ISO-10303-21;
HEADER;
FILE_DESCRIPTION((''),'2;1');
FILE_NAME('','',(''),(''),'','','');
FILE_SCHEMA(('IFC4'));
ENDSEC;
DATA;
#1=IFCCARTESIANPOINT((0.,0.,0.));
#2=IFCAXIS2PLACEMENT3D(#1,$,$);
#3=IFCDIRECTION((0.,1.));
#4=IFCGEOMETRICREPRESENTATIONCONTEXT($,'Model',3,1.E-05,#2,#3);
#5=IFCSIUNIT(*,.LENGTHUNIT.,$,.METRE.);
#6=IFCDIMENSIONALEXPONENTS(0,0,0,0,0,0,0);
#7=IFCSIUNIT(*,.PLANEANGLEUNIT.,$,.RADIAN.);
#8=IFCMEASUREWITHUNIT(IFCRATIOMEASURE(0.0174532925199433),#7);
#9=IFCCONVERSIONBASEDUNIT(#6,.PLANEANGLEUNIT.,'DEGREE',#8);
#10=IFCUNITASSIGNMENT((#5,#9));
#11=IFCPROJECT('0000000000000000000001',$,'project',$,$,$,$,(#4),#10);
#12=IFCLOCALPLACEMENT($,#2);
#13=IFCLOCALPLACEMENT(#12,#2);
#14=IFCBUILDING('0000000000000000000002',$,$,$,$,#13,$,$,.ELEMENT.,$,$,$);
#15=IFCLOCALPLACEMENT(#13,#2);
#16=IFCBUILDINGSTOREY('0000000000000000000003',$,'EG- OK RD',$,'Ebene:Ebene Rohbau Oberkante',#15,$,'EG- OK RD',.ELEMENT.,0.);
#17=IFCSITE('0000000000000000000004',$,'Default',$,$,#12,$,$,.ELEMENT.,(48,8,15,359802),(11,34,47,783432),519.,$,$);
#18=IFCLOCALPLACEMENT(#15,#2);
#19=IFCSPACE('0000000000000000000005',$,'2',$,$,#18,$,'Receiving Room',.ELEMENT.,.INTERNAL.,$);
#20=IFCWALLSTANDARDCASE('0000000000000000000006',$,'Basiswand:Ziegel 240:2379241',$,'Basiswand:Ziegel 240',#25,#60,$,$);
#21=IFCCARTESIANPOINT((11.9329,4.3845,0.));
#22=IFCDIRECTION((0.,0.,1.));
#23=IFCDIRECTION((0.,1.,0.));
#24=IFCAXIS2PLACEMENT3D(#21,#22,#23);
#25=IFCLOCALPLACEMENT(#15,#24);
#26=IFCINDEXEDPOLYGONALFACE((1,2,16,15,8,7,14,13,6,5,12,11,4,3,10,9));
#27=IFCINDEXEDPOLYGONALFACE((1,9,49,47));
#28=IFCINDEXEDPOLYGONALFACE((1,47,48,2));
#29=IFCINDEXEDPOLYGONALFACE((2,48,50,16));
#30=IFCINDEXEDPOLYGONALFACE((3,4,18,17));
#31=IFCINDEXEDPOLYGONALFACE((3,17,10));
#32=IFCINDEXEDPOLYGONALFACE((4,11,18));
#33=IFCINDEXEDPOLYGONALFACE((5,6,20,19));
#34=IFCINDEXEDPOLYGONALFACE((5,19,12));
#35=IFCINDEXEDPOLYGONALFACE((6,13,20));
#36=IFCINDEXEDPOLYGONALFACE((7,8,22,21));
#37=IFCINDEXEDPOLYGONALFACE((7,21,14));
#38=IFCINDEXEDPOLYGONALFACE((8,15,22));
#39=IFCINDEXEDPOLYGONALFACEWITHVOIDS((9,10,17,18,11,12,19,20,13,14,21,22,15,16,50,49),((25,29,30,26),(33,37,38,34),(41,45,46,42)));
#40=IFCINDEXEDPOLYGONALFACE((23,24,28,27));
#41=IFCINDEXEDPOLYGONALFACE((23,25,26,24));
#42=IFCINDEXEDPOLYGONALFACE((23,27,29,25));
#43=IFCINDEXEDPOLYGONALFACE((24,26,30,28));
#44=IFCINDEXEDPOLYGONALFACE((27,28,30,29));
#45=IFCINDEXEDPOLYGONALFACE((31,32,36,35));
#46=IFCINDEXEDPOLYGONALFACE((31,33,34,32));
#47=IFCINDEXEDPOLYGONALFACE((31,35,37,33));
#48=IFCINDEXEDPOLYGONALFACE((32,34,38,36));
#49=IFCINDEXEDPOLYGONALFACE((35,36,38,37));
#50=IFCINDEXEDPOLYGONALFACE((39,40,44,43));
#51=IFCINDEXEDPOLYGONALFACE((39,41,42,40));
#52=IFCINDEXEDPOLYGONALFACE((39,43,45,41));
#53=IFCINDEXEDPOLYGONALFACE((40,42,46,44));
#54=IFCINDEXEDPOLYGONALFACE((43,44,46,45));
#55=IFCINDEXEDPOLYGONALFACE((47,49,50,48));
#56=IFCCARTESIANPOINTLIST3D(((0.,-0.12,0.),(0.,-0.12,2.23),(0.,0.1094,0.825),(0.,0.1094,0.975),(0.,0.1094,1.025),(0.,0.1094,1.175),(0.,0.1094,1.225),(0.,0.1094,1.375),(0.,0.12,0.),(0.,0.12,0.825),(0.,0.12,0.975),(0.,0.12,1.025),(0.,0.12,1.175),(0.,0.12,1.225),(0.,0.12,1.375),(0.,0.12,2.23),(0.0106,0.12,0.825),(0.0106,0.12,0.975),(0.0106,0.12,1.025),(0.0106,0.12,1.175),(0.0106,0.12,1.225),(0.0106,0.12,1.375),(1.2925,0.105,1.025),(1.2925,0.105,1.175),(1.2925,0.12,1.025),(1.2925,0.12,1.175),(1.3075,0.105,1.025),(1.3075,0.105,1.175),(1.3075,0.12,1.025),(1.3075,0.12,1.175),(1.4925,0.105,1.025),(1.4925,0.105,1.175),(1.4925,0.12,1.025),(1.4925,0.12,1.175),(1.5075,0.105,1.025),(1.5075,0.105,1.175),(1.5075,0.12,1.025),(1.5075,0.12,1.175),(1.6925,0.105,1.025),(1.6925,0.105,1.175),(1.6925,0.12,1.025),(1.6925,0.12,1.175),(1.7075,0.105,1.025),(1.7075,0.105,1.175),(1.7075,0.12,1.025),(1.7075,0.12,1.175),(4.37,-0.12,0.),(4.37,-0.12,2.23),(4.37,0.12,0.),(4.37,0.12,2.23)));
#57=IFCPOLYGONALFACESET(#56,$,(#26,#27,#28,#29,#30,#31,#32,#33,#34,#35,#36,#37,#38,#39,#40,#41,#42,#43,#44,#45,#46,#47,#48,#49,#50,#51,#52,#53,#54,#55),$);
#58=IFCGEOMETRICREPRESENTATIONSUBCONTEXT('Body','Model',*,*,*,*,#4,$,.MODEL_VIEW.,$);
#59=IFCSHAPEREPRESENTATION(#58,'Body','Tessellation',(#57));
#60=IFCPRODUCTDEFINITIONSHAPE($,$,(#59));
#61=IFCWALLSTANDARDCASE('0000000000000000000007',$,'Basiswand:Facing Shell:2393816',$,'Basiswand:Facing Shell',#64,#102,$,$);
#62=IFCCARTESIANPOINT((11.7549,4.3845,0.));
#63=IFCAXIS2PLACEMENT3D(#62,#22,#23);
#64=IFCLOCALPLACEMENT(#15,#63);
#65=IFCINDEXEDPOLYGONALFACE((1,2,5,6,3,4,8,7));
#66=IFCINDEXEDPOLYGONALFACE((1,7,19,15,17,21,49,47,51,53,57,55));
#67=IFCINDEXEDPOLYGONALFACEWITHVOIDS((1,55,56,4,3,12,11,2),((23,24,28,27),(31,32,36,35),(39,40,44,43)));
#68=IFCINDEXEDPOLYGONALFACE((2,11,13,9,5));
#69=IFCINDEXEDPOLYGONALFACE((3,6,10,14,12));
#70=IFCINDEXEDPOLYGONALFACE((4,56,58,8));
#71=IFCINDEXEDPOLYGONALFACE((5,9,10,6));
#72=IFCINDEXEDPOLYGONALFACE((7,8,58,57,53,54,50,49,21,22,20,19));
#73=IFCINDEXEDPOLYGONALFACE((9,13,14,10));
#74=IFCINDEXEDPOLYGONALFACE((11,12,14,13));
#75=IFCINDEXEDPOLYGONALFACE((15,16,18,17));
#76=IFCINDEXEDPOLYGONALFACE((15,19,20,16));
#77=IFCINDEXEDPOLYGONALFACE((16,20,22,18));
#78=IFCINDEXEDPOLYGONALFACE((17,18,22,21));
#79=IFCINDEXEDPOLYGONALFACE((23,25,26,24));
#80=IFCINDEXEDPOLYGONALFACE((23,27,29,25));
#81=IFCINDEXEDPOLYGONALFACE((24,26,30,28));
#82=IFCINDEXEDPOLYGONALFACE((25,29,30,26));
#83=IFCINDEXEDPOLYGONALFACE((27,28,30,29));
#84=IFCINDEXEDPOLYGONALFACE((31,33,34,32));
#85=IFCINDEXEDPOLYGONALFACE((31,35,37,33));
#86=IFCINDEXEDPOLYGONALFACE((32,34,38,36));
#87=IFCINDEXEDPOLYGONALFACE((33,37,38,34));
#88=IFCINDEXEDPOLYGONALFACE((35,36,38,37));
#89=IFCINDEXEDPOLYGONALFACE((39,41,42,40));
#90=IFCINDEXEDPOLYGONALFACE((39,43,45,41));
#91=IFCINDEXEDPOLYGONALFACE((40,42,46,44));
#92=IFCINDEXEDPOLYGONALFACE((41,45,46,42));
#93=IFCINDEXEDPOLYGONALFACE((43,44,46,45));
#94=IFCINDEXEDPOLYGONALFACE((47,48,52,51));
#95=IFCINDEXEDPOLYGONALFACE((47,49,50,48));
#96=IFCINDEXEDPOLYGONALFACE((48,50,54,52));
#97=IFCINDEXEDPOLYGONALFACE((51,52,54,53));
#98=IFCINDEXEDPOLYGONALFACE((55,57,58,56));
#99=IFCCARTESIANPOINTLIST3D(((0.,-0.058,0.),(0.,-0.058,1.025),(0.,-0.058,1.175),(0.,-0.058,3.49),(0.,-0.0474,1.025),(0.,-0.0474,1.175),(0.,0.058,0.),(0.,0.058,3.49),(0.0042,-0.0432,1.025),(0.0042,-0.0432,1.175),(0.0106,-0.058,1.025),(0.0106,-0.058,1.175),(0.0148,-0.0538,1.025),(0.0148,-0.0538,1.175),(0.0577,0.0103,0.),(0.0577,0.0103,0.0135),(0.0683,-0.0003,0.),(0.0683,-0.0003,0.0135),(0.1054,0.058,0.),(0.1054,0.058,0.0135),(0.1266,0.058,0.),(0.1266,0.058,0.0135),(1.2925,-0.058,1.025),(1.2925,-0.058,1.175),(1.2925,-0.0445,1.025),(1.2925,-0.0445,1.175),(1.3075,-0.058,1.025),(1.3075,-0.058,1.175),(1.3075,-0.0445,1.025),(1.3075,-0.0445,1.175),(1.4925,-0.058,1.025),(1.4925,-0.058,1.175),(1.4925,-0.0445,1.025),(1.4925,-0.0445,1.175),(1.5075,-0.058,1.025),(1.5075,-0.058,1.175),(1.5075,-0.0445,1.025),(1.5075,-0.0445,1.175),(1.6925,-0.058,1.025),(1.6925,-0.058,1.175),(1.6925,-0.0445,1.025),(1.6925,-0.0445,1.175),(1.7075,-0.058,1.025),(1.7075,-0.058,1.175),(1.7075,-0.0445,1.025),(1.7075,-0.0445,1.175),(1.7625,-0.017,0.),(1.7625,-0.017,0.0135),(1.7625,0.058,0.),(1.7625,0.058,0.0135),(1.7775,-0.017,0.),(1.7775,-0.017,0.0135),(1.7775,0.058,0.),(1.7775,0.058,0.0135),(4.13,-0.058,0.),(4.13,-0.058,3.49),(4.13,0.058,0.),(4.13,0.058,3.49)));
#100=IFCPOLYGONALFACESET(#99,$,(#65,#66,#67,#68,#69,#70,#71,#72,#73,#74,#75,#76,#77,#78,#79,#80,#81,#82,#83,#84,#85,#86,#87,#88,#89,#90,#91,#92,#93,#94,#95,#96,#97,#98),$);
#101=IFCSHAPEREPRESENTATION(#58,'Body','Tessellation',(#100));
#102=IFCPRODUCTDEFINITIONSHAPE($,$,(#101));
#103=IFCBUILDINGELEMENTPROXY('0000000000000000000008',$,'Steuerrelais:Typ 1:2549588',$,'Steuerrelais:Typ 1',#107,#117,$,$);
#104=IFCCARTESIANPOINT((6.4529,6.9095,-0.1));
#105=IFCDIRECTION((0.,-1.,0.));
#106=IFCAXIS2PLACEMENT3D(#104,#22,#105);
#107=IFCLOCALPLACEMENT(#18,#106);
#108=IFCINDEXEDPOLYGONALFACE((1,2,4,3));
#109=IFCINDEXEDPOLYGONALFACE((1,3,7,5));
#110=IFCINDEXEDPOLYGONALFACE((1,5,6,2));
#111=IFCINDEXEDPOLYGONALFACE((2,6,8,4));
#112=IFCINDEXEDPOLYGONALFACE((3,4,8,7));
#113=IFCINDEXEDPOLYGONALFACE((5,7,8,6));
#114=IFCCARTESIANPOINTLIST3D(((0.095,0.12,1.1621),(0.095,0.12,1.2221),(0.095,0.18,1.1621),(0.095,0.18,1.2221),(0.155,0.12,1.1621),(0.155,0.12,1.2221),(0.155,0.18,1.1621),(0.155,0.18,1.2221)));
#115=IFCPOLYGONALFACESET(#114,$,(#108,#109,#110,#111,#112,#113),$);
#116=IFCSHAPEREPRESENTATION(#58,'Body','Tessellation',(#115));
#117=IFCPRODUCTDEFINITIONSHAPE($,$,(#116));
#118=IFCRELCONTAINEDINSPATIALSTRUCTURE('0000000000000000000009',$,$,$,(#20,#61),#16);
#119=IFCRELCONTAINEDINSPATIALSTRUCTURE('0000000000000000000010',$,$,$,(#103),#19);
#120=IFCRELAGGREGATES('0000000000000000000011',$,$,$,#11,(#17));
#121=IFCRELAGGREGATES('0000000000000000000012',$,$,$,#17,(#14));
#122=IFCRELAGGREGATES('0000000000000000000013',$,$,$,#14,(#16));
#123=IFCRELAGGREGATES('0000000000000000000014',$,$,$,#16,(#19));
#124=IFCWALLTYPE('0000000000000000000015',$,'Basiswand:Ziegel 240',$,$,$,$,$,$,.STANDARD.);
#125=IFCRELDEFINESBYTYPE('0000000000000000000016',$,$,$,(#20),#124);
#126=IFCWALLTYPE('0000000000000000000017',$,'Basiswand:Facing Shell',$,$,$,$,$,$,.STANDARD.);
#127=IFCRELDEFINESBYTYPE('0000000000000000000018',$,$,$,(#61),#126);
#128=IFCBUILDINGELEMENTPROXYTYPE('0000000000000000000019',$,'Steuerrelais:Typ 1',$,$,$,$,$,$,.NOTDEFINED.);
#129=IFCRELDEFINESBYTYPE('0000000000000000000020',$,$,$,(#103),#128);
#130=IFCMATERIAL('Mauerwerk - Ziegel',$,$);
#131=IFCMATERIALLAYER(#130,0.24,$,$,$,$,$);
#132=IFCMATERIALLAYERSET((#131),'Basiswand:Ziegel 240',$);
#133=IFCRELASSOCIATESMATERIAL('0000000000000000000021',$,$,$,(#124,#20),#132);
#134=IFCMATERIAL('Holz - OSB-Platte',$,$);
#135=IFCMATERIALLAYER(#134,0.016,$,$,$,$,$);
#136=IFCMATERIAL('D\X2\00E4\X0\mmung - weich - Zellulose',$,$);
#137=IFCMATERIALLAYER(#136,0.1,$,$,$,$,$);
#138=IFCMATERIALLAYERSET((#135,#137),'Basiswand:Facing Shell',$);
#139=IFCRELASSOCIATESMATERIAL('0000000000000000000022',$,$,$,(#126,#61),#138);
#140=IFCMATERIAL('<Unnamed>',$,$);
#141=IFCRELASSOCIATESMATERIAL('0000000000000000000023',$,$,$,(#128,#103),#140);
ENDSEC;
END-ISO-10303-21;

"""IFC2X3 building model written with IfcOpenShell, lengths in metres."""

from ifc_helpers import new_model, entity, si_unit, converted_unit, direction, frame, frame_2d, origin, origin_2d_with_axis, place, context, subcontext, project, spatial, rectangle, extrude, source, transform, mapped, material, layer, layer_set, layer_usage, type_object, type_shapes, element, save


model = new_model("IFC2X3")

# Units and contexts
model_context = context("Model", 3, precision=1e-05, world=origin(), true_north=direction((0.0, 1.0)))
body_context = subcontext(model_context, "Body", "Model", "MODEL_VIEW")
ifc_project = project(units=[si_unit("LENGTHUNIT", "METRE"), converted_unit("PLANEANGLEUNIT", "DEGREE", entity("IfcRatioMeasure", 0.0174532925199433), si_unit("PLANEANGLEUNIT", "RADIAN"), dimensions=[0, 0, 0, 0, 0, 0, 0])], contexts=[model_context])

# Site, building, storey
site_placement = place(None, origin())
site = spatial("IfcSite", under=ifc_project, at=site_placement, Name="Default", CompositionType="ELEMENT", RefLatitude=(48, 8, 15, 359802), RefLongitude=(11, 34, 47, 783432), RefElevation=519.0)
building_placement = place(site_placement, origin())
building = spatial("IfcBuilding", under=site, at=building_placement, CompositionType="ELEMENT")
storey_placement = place(building_placement, origin())
storey = spatial("IfcBuildingStorey", under=building, at=storey_placement, Name="EG- OK RD", ObjectType="Ebene:Ebene Rohbau Oberkante", LongName="EG- OK RD", CompositionType="ELEMENT", Elevation=0.0)

# Wall, openings
ifc_material_1 = material(Name="Mauerwerk - Ziegel")
ifc_layer_1 = layer(ifc_material_1, 0.24)
ifc_layer_set_1 = layer_set([ifc_layer_1], Name="Basiswand:Ziegel 240")
ifc_layer_usage_1 = layer_usage(ifc_layer_set_1, "AXIS2", "POSITIVE", -0.12)
wall_type_1 = type_object("IfcWallType", Name="Basiswand:Ziegel 240", PredefinedType="STANDARD", material=ifc_layer_set_1)
wall_1_placement = place(storey_placement, frame((11.9329, 4.3845, 0.0), z_axis=(0.0, 0.0, 1.0), x_axis=(0.0, 1.0, 0.0)))
wall_1 = element("IfcWallStandardCase", 1, at=wall_1_placement, inside=storey, type_object=wall_type_1, material=ifc_layer_usage_1, Name="Basiswand:Ziegel 240:2379241", ObjectType="Basiswand:Ziegel 240", context=body_context, shape_type="SweptSolid", body=[
    extrude(rectangle(XDim=4.37, YDim=0.24, at=frame_2d((2.185, 0.0), x_axis=(-1.0, 0.0))), origin(), (0.0, 0.0, 1.0), 2.23),
])
opening_1_placement = place(wall_1_placement, origin())
element("IfcOpeningElement", 2, at=opening_1_placement, cuts=wall_1, ObjectType="Recess", context=body_context, shape_type="SweptSolid", body=[
    extrude(rectangle(XDim=0.15, YDim=0.0285, at=frame_2d((0.0, 0.0), x_axis=(0.0, 1.0))), frame((0.0048, 0.1142, 1.1), z_axis=(-0.707107, 0.707107, 0.0), x_axis=(-0.707107, -0.707107, 0.0)), (0.0, 0.0, 1.0), 0.015),
])
opening_2_placement = place(wall_1_placement, origin())
element("IfcOpeningElement", 3, at=opening_2_placement, cuts=wall_1, ObjectType="Recess", context=body_context, shape_type="SweptSolid", body=[
    extrude(rectangle(XDim=0.15, YDim=0.0285, at=frame_2d((0.0, 0.0), x_axis=(0.0, 1.0))), frame((0.0048, 0.1142, 0.9), z_axis=(-0.707107, 0.707107, 0.0), x_axis=(-0.707107, -0.707107, 0.0)), (0.0, 0.0, 1.0), 0.015),
])
opening_3_placement = place(wall_1_placement, origin())
element("IfcOpeningElement", 4, at=opening_3_placement, cuts=wall_1, ObjectType="Recess", context=body_context, shape_type="SweptSolid", body=[
    extrude(rectangle(XDim=0.15, YDim=0.0285, at=frame_2d((0.0, 0.0), x_axis=(0.0, 1.0))), frame((0.0048, 0.1142, 1.3), z_axis=(-0.707107, 0.707107, 0.0), x_axis=(-0.707107, -0.707107, 0.0)), (0.0, 0.0, 1.0), 0.015),
])
opening_4_placement = place(wall_1_placement, origin())
element("IfcOpeningElement", 5, at=opening_4_placement, cuts=wall_1, ObjectType="Recess", context=body_context, shape_type="SweptSolid", body=[
    extrude(rectangle(XDim=0.15, YDim=0.015, at=frame_2d((0.0, 0.0), x_axis=(0.0, 1.0))), frame((1.3, 0.105, 1.1), z_axis=(0.0, 1.0, 0.0), x_axis=(-1.0, 0.0, 0.0)), (0.0, 0.0, 1.0), 0.0285),
])
opening_5_placement = place(wall_1_placement, origin())
element("IfcOpeningElement", 6, at=opening_5_placement, cuts=wall_1, ObjectType="Recess", context=body_context, shape_type="SweptSolid", body=[
    extrude(rectangle(XDim=0.15, YDim=0.015, at=frame_2d((0.0, 0.0), x_axis=(0.0, 1.0))), frame((1.5, 0.105, 1.1), z_axis=(0.0, 1.0, 0.0), x_axis=(-1.0, 0.0, 0.0)), (0.0, 0.0, 1.0), 0.0285),
])
opening_6_placement = place(wall_1_placement, origin())
element("IfcOpeningElement", 7, at=opening_6_placement, cuts=wall_1, ObjectType="Recess", context=body_context, shape_type="SweptSolid", body=[
    extrude(rectangle(XDim=0.15, YDim=0.015, at=frame_2d((0.0, 0.0), x_axis=(0.0, 1.0))), frame((1.7, 0.105, 1.1), z_axis=(0.0, 1.0, 0.0), x_axis=(-1.0, 0.0, 0.0)), (0.0, 0.0, 1.0), 0.0285),
])

# Wall, openings
ifc_material_2 = material(Name="Holz - OSB-Platte")
ifc_layer_2 = layer(ifc_material_2, 0.016)
ifc_material_3 = material(Name="Dämmung - weich - Zellulose")
ifc_layer_3 = layer(ifc_material_3, 0.1)
ifc_layer_set_2 = layer_set([ifc_layer_2, ifc_layer_3], Name="Basiswand:Facing Shell")
ifc_layer_usage_2 = layer_usage(ifc_layer_set_2, "AXIS2", "NEGATIVE", 0.058)
wall_type_2 = type_object("IfcWallType", Name="Basiswand:Facing Shell", PredefinedType="STANDARD", material=ifc_layer_set_2)
wall_2_placement = place(storey_placement, frame((11.7549, 4.3845, 0.0), z_axis=(0.0, 0.0, 1.0), x_axis=(0.0, 1.0, 0.0)))
wall_2 = element("IfcWallStandardCase", 8, at=wall_2_placement, inside=storey, type_object=wall_type_2, material=ifc_layer_usage_2, Name="Basiswand:Facing Shell:2393816", ObjectType="Basiswand:Facing Shell", context=body_context, shape_type="SweptSolid", body=[
    extrude(rectangle(XDim=4.13, YDim=0.116, at=frame_2d((2.065, 0.0), x_axis=(-1.0, 0.0))), origin(), (0.0, 0.0, 1.0), 3.49),
])
opening_7_placement = place(wall_2_placement, origin())
element("IfcOpeningElement", 9, at=opening_7_placement, cuts=wall_2, ObjectType="Recess", context=body_context, shape_type="SweptSolid", body=[
    extrude(rectangle(XDim=0.15, YDim=0.015, at=frame_2d((0.0, 0.0), x_axis=(0.0, 1.0))), frame((1.3, -0.073, 1.1), z_axis=(0.0, 1.0, 0.0), x_axis=(-1.0, 0.0, 0.0)), (0.0, 0.0, 1.0), 0.0285),
])
opening_8_placement = place(wall_2_placement, origin())
element("IfcOpeningElement", 10, at=opening_8_placement, cuts=wall_2, ObjectType="Recess", context=body_context, shape_type="SweptSolid", body=[
    extrude(rectangle(XDim=0.15, YDim=0.015, at=frame_2d((0.0, 0.0), x_axis=(0.0, 1.0))), frame((1.5, -0.073, 1.1), z_axis=(0.0, 1.0, 0.0), x_axis=(-1.0, 0.0, 0.0)), (0.0, 0.0, 1.0), 0.0285),
])
opening_9_placement = place(wall_2_placement, origin())
element("IfcOpeningElement", 11, at=opening_9_placement, cuts=wall_2, ObjectType="Recess", context=body_context, shape_type="SweptSolid", body=[
    extrude(rectangle(XDim=0.15, YDim=0.015, at=frame_2d((0.0, 0.0), x_axis=(0.0, 1.0))), frame((1.7, -0.073, 1.1), z_axis=(0.0, 1.0, 0.0), x_axis=(-1.0, 0.0, 0.0)), (0.0, 0.0, 1.0), 0.0285),
])
opening_10_placement = place(wall_2_placement, origin())
element("IfcOpeningElement", 12, at=opening_10_placement, cuts=wall_2, ObjectType="Recess", context=body_context, shape_type="SweptSolid", body=[
    extrude(rectangle(XDim=0.15, YDim=0.0285, at=frame_2d((0.0, 0.0), x_axis=(0.0, 1.0))), frame((0.0048, -0.0638, 1.1), z_axis=(-0.707107, 0.707107, 0.0), x_axis=(-0.707107, -0.707107, 0.0)), (0.0, 0.0, 1.0), 0.015),
])
opening_11_placement = place(wall_2_placement, origin())
element("IfcOpeningElement", 13, at=opening_11_placement, cuts=wall_2, ObjectType="Recess", context=body_context, shape_type="SweptSolid", body=[
    extrude(rectangle(XDim=0.0285, YDim=0.15, at=frame_2d((0.0, 0.0), x_axis=(1.0, 0.0))), frame((0.1213, 0.0527, -0.0007), z_axis=(-0.707107, 0.707107, 0.0), x_axis=(0.0, 0.0, -1.0)), (0.0, 0.0, 1.0), 0.015),
])
opening_12_placement = place(wall_2_placement, origin())
element("IfcOpeningElement", 14, at=opening_12_placement, cuts=wall_2, ObjectType="Opening", context=body_context, shape_type="SweptSolid", body=[
    extrude(rectangle(XDim=0.0285, YDim=0.015, at=frame_2d((0.0, 0.0), x_axis=(1.0, 0.0))), frame((1.77, -0.017, -0.0007), z_axis=(0.0, 1.0, 0.0), x_axis=(0.0, 0.0, -1.0)), (0.0, 0.0, 1.0), 0.15),
])

# Shared definitions
space_placement = place(storey_placement, origin())
space = spatial("IfcSpace", under=storey, at=space_placement, Name="2", LongName="Receiving Room", CompositionType="ELEMENT", InteriorOrExteriorSpace="INTERNAL")

# Building element proxy
ifc_material_4 = material(Name="<Unnamed>")
building_element_proxy_type = type_object("IfcBuildingElementProxyType", Name="Steuerrelais:Typ 1", PredefinedType="NOTDEFINED", material=ifc_material_4)
shared_shape = source(origin(), body_context, "Body", "SweptSolid", [
    extrude(rectangle(XDim=0.06, YDim=0.06, at=origin_2d_with_axis()), frame((0.125, 0.15, 1.1621), z_axis=(0.0, 0.0, 1.0), x_axis=(0.0, 1.0, 0.0)), (0.0, 0.0, 1.0), 0.06),
])
type_shapes(building_element_proxy_type, [shared_shape])
proxy_placement = place(space_placement, frame((6.4529, 6.9095, -0.1), z_axis=(0.0, 0.0, 1.0), x_axis=(0.0, -1.0, 0.0)))
element("IfcBuildingElementProxy", 15, at=proxy_placement, inside=space, type_object=building_element_proxy_type, material=ifc_material_4, Name="Steuerrelais:Typ 1:2549588", ObjectType="Steuerrelais:Typ 1", context=body_context, shape_type="MappedRepresentation", body=[
    mapped(shared_shape, transform((0.0, 0.0, 0.0), scale=1.0)),
])

save(model, "model.ifc")
